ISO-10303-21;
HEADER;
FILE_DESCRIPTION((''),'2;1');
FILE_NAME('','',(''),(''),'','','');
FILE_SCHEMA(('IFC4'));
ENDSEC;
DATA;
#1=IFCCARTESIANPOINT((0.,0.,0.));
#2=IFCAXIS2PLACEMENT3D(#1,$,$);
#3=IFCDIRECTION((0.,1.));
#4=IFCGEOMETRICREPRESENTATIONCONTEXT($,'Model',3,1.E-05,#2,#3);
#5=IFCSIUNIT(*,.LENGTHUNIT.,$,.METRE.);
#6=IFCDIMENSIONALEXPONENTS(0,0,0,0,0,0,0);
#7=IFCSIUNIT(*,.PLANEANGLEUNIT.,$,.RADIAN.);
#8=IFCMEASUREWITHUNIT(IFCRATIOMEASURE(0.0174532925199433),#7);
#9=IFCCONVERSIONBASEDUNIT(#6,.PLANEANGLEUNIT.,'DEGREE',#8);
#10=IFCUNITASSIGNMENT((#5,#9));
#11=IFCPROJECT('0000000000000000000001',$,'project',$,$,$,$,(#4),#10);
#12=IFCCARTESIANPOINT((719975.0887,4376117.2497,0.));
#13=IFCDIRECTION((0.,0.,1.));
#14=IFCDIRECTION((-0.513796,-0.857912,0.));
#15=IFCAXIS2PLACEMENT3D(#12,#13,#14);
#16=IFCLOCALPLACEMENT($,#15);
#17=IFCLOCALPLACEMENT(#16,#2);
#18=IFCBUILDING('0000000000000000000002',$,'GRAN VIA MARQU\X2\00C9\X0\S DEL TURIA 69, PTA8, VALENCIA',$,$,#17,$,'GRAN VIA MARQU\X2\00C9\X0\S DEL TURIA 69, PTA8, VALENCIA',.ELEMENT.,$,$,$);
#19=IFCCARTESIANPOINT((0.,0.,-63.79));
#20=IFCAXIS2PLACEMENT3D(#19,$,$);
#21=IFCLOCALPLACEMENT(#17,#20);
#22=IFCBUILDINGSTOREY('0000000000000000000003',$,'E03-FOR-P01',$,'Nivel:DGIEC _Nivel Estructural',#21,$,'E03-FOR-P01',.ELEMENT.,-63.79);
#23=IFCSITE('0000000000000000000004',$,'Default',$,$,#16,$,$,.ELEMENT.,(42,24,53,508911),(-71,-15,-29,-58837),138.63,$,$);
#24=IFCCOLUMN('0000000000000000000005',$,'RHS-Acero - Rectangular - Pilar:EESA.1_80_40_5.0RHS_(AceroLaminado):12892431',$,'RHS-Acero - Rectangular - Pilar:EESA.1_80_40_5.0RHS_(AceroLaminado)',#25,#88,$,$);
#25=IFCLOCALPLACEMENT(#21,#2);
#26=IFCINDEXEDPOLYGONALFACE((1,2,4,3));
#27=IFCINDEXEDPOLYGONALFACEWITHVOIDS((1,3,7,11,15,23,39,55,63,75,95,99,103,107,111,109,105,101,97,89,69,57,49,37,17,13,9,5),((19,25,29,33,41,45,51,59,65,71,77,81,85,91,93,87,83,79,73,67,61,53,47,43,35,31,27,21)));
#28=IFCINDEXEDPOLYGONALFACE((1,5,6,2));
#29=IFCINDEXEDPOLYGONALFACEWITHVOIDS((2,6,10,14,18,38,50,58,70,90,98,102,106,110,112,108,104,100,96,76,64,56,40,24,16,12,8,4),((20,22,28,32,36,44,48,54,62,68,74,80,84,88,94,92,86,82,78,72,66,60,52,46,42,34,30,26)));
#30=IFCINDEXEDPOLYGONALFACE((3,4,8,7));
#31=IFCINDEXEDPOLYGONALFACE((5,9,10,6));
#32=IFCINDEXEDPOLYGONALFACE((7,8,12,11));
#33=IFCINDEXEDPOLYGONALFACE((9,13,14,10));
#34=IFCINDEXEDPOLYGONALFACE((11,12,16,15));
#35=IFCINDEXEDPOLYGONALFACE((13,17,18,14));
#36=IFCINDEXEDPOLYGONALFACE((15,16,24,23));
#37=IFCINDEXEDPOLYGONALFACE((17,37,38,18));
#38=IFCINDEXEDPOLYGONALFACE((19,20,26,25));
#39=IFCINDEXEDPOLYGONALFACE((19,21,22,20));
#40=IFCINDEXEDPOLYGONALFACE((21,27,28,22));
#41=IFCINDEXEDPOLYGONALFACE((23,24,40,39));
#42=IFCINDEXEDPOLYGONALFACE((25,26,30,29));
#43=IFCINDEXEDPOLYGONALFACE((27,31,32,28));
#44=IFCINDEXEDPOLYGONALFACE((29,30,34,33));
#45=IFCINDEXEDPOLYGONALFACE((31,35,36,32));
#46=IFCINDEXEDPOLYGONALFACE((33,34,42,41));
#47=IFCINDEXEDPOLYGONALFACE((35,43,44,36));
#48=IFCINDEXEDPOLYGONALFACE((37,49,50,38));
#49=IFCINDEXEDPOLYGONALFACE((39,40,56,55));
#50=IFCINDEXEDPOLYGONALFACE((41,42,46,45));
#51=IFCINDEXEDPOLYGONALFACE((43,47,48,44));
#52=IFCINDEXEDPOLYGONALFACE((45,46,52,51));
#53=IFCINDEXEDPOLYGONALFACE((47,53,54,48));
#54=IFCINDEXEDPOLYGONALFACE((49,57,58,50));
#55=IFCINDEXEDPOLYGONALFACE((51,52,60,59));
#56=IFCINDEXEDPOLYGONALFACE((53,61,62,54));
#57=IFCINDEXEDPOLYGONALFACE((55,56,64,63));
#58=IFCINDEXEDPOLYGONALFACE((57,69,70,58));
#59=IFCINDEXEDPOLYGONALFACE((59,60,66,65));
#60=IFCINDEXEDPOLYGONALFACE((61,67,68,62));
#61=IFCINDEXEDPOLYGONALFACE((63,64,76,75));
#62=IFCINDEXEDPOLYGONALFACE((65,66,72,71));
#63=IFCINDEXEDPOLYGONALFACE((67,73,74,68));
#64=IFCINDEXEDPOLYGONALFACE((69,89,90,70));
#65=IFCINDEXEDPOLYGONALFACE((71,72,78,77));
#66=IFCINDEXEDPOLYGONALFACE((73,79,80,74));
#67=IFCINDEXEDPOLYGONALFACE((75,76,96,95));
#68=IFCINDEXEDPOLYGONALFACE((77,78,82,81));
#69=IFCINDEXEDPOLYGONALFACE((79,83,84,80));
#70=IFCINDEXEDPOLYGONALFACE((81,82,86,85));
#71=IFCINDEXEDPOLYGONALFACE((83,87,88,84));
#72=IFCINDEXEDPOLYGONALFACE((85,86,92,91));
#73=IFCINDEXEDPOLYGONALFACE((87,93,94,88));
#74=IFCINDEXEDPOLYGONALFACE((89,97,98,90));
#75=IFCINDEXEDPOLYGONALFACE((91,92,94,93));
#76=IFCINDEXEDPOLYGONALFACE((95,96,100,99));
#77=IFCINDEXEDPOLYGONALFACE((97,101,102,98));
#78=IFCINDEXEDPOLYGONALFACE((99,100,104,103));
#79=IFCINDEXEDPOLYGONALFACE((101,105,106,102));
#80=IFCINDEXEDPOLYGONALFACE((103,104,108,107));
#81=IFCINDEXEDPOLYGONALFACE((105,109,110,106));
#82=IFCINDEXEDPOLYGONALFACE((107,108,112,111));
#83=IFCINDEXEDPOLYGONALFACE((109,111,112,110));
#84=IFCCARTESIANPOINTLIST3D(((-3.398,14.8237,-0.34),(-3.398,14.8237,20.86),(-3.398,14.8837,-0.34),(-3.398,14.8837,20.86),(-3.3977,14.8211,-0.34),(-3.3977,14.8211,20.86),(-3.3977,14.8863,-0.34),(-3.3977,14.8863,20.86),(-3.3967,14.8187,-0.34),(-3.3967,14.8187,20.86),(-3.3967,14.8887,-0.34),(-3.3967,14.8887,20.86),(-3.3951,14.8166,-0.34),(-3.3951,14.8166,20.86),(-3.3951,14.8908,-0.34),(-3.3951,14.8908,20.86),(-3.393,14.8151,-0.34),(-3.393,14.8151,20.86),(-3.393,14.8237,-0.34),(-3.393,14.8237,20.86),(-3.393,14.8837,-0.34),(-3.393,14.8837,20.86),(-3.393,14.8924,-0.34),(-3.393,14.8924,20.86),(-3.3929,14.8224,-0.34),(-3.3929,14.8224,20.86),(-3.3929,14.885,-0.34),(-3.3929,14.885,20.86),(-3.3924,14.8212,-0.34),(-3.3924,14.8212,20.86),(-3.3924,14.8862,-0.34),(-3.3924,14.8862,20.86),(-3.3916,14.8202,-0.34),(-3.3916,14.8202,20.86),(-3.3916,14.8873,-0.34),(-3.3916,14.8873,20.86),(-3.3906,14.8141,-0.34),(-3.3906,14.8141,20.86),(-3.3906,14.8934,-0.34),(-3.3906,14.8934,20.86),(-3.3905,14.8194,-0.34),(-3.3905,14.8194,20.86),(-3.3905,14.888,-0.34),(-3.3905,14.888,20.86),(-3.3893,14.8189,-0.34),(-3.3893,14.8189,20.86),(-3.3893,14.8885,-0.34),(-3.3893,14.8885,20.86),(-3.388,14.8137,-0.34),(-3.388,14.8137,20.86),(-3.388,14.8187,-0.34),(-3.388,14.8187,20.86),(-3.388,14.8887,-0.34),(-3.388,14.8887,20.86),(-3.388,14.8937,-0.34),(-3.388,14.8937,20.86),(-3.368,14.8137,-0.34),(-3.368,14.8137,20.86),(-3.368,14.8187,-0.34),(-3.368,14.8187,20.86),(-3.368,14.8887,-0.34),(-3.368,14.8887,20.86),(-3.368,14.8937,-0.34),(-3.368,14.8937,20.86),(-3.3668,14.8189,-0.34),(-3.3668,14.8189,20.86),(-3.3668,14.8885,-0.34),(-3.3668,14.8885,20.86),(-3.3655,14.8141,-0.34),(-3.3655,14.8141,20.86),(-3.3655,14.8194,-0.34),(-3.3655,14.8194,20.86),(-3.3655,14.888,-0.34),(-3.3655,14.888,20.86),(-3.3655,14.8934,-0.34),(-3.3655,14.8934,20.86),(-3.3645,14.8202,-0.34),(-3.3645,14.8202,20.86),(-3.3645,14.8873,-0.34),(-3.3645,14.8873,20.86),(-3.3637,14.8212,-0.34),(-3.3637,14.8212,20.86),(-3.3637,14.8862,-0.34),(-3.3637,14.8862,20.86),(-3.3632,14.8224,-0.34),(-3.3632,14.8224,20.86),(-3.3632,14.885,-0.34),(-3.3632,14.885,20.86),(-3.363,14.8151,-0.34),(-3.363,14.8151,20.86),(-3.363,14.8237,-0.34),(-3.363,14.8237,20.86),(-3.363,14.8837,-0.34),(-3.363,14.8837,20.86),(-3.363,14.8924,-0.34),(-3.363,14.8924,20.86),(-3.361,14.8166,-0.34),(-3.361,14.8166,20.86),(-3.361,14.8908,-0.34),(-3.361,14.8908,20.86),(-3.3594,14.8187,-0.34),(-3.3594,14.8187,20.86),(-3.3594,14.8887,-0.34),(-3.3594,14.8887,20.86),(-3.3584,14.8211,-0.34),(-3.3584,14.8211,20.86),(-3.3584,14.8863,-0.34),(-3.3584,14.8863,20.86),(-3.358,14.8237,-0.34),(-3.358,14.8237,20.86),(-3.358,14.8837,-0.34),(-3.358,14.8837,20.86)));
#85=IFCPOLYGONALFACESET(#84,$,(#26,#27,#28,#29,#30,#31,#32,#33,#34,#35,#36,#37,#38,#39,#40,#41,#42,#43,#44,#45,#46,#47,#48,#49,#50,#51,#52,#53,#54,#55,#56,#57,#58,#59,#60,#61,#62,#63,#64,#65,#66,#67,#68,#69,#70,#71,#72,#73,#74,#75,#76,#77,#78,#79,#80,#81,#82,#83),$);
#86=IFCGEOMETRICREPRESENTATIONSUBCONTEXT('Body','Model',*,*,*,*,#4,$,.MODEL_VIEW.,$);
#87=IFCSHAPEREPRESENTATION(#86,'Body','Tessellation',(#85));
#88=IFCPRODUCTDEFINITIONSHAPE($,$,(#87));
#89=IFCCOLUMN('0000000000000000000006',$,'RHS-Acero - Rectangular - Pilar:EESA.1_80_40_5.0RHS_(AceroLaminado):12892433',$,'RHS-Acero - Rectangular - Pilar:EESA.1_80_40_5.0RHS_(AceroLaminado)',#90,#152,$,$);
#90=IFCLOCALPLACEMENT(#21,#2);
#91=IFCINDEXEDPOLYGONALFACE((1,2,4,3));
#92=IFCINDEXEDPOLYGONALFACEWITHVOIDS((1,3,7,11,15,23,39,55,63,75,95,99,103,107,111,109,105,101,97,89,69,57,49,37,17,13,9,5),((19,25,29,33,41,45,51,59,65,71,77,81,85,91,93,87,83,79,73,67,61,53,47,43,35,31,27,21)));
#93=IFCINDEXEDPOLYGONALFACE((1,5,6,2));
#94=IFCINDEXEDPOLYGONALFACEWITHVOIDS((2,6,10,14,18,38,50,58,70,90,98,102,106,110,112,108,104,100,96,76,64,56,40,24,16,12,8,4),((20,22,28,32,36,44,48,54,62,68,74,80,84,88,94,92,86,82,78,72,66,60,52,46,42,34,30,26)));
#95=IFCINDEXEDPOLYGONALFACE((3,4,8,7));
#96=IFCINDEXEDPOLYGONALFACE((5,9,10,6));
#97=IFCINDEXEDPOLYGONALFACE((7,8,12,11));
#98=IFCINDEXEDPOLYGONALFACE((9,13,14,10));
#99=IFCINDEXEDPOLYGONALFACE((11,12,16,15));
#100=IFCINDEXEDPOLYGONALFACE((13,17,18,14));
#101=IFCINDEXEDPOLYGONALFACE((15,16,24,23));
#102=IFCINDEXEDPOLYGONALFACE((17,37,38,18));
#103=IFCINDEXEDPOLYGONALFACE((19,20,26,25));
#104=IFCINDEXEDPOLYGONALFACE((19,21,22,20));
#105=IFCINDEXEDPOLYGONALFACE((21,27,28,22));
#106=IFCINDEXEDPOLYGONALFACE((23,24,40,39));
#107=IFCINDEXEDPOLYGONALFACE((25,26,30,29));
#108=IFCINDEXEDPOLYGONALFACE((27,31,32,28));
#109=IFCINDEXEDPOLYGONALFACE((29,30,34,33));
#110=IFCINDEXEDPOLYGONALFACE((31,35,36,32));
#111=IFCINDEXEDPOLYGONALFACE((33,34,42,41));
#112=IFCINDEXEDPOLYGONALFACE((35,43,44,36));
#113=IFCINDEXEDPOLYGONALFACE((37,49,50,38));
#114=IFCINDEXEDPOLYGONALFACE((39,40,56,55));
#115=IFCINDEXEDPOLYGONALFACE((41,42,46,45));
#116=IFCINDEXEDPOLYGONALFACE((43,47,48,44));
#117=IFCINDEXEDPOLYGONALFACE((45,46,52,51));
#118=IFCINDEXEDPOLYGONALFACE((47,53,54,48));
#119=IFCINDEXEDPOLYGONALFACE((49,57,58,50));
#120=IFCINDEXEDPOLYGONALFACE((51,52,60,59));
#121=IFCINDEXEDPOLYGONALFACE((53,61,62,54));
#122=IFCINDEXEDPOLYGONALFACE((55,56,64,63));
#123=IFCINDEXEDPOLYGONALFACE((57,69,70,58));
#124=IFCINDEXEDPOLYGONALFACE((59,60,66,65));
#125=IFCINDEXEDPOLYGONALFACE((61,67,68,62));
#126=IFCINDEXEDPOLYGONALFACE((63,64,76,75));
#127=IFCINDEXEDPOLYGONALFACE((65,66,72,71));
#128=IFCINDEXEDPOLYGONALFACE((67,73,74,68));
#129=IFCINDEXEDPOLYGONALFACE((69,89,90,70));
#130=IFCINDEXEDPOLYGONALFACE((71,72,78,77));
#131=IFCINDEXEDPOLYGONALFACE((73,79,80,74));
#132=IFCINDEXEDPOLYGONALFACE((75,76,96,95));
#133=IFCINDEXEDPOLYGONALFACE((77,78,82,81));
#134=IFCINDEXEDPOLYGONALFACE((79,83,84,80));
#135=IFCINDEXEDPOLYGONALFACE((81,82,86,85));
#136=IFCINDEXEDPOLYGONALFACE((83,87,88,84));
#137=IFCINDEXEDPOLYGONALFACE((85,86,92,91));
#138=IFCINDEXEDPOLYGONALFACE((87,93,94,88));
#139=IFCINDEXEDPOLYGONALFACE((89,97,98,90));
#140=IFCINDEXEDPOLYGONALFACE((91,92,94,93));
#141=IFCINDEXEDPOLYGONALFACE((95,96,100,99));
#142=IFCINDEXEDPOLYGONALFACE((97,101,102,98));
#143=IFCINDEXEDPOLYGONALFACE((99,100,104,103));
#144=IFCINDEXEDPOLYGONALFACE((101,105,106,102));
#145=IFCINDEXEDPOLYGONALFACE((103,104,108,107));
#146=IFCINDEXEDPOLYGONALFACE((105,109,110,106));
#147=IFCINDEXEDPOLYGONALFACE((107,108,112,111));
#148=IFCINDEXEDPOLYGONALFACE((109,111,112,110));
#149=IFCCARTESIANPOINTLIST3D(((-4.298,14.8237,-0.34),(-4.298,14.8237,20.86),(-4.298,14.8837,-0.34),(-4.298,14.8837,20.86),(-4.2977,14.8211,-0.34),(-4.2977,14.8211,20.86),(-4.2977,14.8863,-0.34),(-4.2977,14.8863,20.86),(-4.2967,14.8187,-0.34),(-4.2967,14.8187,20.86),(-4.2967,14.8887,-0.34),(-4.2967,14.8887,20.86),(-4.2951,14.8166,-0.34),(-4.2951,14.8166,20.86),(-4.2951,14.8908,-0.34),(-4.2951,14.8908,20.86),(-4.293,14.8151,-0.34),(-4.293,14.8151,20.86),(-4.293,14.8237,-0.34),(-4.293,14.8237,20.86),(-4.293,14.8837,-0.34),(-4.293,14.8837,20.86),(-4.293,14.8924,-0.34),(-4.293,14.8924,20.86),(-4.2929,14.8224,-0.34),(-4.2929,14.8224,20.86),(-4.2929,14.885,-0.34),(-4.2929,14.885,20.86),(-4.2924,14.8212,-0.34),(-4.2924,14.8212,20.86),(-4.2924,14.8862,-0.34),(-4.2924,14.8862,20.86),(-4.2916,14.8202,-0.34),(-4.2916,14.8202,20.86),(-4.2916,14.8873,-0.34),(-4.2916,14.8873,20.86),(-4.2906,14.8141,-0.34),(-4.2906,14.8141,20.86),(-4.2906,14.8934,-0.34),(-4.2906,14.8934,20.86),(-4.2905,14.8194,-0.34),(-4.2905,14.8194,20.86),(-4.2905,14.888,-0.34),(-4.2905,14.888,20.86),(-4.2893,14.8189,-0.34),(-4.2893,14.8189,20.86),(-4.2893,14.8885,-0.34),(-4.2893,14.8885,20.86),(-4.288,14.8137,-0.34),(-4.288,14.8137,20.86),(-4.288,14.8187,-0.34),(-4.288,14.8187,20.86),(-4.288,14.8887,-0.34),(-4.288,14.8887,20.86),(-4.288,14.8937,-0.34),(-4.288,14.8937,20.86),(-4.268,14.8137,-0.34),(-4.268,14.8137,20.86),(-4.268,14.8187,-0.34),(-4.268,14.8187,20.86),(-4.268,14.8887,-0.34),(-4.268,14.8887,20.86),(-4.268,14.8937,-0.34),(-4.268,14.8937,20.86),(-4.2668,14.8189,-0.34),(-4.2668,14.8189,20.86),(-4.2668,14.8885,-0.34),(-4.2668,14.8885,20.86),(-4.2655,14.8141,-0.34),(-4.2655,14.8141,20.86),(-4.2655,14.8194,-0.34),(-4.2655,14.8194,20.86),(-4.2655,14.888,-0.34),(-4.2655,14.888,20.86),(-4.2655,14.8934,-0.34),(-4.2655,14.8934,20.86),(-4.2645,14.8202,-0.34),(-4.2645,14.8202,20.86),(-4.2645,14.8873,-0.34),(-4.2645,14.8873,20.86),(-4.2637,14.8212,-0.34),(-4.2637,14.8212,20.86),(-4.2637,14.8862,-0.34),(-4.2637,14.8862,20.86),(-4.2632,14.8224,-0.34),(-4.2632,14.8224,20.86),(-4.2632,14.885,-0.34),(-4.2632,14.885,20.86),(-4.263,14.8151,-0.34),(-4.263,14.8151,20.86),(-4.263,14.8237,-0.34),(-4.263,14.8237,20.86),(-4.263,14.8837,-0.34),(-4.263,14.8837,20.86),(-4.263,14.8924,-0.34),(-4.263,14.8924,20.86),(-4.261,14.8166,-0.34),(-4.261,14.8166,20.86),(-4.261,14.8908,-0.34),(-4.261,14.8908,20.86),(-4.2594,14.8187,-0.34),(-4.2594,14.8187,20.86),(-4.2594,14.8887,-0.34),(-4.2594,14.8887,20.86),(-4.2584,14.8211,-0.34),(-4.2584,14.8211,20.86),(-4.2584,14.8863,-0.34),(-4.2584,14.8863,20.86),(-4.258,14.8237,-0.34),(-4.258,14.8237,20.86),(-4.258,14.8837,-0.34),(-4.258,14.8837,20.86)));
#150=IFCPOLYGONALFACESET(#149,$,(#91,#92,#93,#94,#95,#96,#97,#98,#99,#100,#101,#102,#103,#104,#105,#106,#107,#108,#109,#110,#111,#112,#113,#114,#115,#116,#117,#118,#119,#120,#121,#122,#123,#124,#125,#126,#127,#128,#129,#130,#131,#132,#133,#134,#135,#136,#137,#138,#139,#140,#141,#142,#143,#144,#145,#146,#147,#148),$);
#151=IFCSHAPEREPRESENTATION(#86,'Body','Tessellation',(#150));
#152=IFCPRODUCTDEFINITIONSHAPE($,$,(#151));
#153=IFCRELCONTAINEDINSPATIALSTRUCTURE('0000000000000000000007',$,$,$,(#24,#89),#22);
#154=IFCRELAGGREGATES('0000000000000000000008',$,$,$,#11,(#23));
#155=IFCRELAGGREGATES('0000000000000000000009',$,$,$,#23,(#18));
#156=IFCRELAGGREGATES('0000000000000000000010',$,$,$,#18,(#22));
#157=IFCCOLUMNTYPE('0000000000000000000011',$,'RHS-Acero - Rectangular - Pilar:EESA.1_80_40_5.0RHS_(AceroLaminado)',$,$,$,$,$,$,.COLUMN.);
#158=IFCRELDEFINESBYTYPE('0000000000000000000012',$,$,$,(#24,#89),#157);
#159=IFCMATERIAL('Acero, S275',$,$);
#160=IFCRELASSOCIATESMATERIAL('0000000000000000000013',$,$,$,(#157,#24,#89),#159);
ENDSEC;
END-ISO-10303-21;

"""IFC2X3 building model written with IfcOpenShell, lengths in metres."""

from ifc_helpers import new_model, entity, si_unit, converted_unit, direction, frame, frame_2d, origin, place, context, subcontext, project, spatial, polyline, circle_curve, parameter, trimmed, segment, composite_curve, outline, extrude, source, transform, mapped, material, type_object, type_shapes, element, save


model = new_model("IFC2X3")

# Units and contexts
model_context = context("Model", 3, precision=1e-05, world=origin(), true_north=direction((0.0, 1.0)))
body_context = subcontext(model_context, "Body", "Model", "MODEL_VIEW")
ifc_project = project(units=[si_unit("LENGTHUNIT", "METRE"), converted_unit("PLANEANGLEUNIT", "DEGREE", entity("IfcRatioMeasure", 0.0174532925199433), si_unit("PLANEANGLEUNIT", "RADIAN"), dimensions=[0, 0, 0, 0, 0, 0, 0])], contexts=[model_context])

# Site, building, storey
site_placement = place(None, frame((719975.0887, 4376117.2497, 0.0), z_axis=(0.0, 0.0, 1.0), x_axis=(-0.513796, -0.857912, 0.0)))
site = spatial("IfcSite", under=ifc_project, at=site_placement, Name="Default", CompositionType="ELEMENT", RefLatitude=(42, 24, 53, 508911), RefLongitude=(-71, -15, -29, -58837), RefElevation=138.63)
building_placement = place(site_placement, origin())
building = spatial("IfcBuilding", under=site, at=building_placement, Name="GRAN VIA MARQUÉS DEL TURIA 69, PTA8, VALENCIA", LongName="GRAN VIA MARQUÉS DEL TURIA 69, PTA8, VALENCIA", CompositionType="ELEMENT")
storey_placement = place(building_placement, frame((0.0, 0.0, -63.79)))
storey = spatial("IfcBuildingStorey", under=building, at=storey_placement, Name="E03-FOR-P01", ObjectType="Nivel:DGIEC _Nivel Estructural", LongName="E03-FOR-P01", CompositionType="ELEMENT", Elevation=-63.79)

# Columns
ifc_material_1 = material(Name="Acero, S275")
column_type_1 = type_object("IfcColumnType", Name="RHS-Acero - Rectangular - Pilar:EESA.1_80_40_5.0RHS_(AceroLaminado)", PredefinedType="COLUMN", material=ifc_material_1)
shared_shape_1 = source(origin(), body_context, "Body", "SweptSolid", [
    extrude(outline(composite_curve([segment(polyline([(-0.01, -0.04), (0.01, -0.04)]), True, "CONTINUOUS"), segment(trimmed(circle_curve(frame_2d((0.01, -0.03), x_axis=(-1.0, 0.0)), 0.01), [parameter(90.0)], [parameter(180.0)], True, "PARAMETER"), True, "CONTINUOUS"), segment(polyline([(0.02, -0.03), (0.02, 0.03)]), True, "CONTINUOUS"), segment(trimmed(circle_curve(frame_2d((0.01, 0.03), x_axis=(-1.0, 0.0)), 0.01), [parameter(180.0)], [parameter(270.0)], True, "PARAMETER"), True, "CONTINUOUS"), segment(polyline([(0.01, 0.04), (-0.01, 0.04)]), True, "CONTINUOUS"), segment(trimmed(circle_curve(frame_2d((-0.01, 0.03), x_axis=(-1.0, 0.0)), 0.01), [parameter(270.0)], [parameter(360.0)], True, "PARAMETER"), True, "CONTINUOUS"), segment(polyline([(-0.02, 0.03), (-0.02, -0.03)]), True, "CONTINUOUS"), segment(trimmed(circle_curve(frame_2d((-0.01, -0.03), x_axis=(-1.0, 0.0)), 0.01), [parameter(360.0)], [parameter(90.0)], True, "PARAMETER"), True, "CONTINUOUS")], self_intersect=False), holes=[composite_curve([segment(trimmed(circle_curve(frame_2d((-0.01, -0.03), x_axis=(-1.0, 0.0)), 0.005), [parameter(0.0)], [parameter(90.0)], True, "PARAMETER"), False, "CONTINUOUS"), segment(polyline([(-0.015, -0.03), (-0.015, 0.03)]), True, "CONTINUOUS"), segment(trimmed(circle_curve(frame_2d((-0.01, 0.03), x_axis=(-1.0, 0.0)), 0.005), [parameter(270.0)], [parameter(0.0)], True, "PARAMETER"), False, "CONTINUOUS"), segment(polyline([(-0.01, 0.035), (0.01, 0.035)]), True, "CONTINUOUS"), segment(trimmed(circle_curve(frame_2d((0.01, 0.03), x_axis=(-1.0, 0.0)), 0.005), [parameter(180.0)], [parameter(270.0)], True, "PARAMETER"), False, "CONTINUOUS"), segment(polyline([(0.015, 0.03), (0.015, -0.03)]), True, "CONTINUOUS"), segment(trimmed(circle_curve(frame_2d((0.01, -0.03), x_axis=(-1.0, 0.0)), 0.005), [parameter(90.0)], [parameter(180.0)], True, "PARAMETER"), False, "CONTINUOUS"), segment(polyline([(0.01, -0.035), (-0.01, -0.035)]), True, "CONTINUOUS")], self_intersect=False)]), frame((0.0, 0.0, -64.13), z_axis=(0.0, 0.0, 1.0), x_axis=(-1.0, 0.0, 0.0)), (0.0, 0.0, 1.0), 21.2),
])
type_shapes(column_type_1, [shared_shape_1])
for number, where, z_axis, x_axis, name in (
    (1, (-3.378, 14.8537, 63.79), (0.0, 0.0, 1.0), (-1.0, 0.0, 0.0), "RHS-Acero - Rectangular - Pilar:EESA.1_80_40_5.0RHS_(AceroLaminado):12892431"),
    (2, (-4.278, 14.8537, 63.79), (0.0, 0.0, 1.0), (-1.0, 0.0, 0.0), "RHS-Acero - Rectangular - Pilar:EESA.1_80_40_5.0RHS_(AceroLaminado):12892433"),
):
    element("IfcColumn", number, at=place(storey_placement, frame(where, z_axis=z_axis, x_axis=x_axis)), inside=storey, type_object=column_type_1, material=ifc_material_1, Name=name, ObjectType="RHS-Acero - Rectangular - Pilar:EESA.1_80_40_5.0RHS_(AceroLaminado)", context=body_context, shape_type="MappedRepresentation", body=[
        mapped(shared_shape_1, transform((0.0, 0.0, 0.0), scale=1.0)),
    ])

save(model, "model.ifc")
